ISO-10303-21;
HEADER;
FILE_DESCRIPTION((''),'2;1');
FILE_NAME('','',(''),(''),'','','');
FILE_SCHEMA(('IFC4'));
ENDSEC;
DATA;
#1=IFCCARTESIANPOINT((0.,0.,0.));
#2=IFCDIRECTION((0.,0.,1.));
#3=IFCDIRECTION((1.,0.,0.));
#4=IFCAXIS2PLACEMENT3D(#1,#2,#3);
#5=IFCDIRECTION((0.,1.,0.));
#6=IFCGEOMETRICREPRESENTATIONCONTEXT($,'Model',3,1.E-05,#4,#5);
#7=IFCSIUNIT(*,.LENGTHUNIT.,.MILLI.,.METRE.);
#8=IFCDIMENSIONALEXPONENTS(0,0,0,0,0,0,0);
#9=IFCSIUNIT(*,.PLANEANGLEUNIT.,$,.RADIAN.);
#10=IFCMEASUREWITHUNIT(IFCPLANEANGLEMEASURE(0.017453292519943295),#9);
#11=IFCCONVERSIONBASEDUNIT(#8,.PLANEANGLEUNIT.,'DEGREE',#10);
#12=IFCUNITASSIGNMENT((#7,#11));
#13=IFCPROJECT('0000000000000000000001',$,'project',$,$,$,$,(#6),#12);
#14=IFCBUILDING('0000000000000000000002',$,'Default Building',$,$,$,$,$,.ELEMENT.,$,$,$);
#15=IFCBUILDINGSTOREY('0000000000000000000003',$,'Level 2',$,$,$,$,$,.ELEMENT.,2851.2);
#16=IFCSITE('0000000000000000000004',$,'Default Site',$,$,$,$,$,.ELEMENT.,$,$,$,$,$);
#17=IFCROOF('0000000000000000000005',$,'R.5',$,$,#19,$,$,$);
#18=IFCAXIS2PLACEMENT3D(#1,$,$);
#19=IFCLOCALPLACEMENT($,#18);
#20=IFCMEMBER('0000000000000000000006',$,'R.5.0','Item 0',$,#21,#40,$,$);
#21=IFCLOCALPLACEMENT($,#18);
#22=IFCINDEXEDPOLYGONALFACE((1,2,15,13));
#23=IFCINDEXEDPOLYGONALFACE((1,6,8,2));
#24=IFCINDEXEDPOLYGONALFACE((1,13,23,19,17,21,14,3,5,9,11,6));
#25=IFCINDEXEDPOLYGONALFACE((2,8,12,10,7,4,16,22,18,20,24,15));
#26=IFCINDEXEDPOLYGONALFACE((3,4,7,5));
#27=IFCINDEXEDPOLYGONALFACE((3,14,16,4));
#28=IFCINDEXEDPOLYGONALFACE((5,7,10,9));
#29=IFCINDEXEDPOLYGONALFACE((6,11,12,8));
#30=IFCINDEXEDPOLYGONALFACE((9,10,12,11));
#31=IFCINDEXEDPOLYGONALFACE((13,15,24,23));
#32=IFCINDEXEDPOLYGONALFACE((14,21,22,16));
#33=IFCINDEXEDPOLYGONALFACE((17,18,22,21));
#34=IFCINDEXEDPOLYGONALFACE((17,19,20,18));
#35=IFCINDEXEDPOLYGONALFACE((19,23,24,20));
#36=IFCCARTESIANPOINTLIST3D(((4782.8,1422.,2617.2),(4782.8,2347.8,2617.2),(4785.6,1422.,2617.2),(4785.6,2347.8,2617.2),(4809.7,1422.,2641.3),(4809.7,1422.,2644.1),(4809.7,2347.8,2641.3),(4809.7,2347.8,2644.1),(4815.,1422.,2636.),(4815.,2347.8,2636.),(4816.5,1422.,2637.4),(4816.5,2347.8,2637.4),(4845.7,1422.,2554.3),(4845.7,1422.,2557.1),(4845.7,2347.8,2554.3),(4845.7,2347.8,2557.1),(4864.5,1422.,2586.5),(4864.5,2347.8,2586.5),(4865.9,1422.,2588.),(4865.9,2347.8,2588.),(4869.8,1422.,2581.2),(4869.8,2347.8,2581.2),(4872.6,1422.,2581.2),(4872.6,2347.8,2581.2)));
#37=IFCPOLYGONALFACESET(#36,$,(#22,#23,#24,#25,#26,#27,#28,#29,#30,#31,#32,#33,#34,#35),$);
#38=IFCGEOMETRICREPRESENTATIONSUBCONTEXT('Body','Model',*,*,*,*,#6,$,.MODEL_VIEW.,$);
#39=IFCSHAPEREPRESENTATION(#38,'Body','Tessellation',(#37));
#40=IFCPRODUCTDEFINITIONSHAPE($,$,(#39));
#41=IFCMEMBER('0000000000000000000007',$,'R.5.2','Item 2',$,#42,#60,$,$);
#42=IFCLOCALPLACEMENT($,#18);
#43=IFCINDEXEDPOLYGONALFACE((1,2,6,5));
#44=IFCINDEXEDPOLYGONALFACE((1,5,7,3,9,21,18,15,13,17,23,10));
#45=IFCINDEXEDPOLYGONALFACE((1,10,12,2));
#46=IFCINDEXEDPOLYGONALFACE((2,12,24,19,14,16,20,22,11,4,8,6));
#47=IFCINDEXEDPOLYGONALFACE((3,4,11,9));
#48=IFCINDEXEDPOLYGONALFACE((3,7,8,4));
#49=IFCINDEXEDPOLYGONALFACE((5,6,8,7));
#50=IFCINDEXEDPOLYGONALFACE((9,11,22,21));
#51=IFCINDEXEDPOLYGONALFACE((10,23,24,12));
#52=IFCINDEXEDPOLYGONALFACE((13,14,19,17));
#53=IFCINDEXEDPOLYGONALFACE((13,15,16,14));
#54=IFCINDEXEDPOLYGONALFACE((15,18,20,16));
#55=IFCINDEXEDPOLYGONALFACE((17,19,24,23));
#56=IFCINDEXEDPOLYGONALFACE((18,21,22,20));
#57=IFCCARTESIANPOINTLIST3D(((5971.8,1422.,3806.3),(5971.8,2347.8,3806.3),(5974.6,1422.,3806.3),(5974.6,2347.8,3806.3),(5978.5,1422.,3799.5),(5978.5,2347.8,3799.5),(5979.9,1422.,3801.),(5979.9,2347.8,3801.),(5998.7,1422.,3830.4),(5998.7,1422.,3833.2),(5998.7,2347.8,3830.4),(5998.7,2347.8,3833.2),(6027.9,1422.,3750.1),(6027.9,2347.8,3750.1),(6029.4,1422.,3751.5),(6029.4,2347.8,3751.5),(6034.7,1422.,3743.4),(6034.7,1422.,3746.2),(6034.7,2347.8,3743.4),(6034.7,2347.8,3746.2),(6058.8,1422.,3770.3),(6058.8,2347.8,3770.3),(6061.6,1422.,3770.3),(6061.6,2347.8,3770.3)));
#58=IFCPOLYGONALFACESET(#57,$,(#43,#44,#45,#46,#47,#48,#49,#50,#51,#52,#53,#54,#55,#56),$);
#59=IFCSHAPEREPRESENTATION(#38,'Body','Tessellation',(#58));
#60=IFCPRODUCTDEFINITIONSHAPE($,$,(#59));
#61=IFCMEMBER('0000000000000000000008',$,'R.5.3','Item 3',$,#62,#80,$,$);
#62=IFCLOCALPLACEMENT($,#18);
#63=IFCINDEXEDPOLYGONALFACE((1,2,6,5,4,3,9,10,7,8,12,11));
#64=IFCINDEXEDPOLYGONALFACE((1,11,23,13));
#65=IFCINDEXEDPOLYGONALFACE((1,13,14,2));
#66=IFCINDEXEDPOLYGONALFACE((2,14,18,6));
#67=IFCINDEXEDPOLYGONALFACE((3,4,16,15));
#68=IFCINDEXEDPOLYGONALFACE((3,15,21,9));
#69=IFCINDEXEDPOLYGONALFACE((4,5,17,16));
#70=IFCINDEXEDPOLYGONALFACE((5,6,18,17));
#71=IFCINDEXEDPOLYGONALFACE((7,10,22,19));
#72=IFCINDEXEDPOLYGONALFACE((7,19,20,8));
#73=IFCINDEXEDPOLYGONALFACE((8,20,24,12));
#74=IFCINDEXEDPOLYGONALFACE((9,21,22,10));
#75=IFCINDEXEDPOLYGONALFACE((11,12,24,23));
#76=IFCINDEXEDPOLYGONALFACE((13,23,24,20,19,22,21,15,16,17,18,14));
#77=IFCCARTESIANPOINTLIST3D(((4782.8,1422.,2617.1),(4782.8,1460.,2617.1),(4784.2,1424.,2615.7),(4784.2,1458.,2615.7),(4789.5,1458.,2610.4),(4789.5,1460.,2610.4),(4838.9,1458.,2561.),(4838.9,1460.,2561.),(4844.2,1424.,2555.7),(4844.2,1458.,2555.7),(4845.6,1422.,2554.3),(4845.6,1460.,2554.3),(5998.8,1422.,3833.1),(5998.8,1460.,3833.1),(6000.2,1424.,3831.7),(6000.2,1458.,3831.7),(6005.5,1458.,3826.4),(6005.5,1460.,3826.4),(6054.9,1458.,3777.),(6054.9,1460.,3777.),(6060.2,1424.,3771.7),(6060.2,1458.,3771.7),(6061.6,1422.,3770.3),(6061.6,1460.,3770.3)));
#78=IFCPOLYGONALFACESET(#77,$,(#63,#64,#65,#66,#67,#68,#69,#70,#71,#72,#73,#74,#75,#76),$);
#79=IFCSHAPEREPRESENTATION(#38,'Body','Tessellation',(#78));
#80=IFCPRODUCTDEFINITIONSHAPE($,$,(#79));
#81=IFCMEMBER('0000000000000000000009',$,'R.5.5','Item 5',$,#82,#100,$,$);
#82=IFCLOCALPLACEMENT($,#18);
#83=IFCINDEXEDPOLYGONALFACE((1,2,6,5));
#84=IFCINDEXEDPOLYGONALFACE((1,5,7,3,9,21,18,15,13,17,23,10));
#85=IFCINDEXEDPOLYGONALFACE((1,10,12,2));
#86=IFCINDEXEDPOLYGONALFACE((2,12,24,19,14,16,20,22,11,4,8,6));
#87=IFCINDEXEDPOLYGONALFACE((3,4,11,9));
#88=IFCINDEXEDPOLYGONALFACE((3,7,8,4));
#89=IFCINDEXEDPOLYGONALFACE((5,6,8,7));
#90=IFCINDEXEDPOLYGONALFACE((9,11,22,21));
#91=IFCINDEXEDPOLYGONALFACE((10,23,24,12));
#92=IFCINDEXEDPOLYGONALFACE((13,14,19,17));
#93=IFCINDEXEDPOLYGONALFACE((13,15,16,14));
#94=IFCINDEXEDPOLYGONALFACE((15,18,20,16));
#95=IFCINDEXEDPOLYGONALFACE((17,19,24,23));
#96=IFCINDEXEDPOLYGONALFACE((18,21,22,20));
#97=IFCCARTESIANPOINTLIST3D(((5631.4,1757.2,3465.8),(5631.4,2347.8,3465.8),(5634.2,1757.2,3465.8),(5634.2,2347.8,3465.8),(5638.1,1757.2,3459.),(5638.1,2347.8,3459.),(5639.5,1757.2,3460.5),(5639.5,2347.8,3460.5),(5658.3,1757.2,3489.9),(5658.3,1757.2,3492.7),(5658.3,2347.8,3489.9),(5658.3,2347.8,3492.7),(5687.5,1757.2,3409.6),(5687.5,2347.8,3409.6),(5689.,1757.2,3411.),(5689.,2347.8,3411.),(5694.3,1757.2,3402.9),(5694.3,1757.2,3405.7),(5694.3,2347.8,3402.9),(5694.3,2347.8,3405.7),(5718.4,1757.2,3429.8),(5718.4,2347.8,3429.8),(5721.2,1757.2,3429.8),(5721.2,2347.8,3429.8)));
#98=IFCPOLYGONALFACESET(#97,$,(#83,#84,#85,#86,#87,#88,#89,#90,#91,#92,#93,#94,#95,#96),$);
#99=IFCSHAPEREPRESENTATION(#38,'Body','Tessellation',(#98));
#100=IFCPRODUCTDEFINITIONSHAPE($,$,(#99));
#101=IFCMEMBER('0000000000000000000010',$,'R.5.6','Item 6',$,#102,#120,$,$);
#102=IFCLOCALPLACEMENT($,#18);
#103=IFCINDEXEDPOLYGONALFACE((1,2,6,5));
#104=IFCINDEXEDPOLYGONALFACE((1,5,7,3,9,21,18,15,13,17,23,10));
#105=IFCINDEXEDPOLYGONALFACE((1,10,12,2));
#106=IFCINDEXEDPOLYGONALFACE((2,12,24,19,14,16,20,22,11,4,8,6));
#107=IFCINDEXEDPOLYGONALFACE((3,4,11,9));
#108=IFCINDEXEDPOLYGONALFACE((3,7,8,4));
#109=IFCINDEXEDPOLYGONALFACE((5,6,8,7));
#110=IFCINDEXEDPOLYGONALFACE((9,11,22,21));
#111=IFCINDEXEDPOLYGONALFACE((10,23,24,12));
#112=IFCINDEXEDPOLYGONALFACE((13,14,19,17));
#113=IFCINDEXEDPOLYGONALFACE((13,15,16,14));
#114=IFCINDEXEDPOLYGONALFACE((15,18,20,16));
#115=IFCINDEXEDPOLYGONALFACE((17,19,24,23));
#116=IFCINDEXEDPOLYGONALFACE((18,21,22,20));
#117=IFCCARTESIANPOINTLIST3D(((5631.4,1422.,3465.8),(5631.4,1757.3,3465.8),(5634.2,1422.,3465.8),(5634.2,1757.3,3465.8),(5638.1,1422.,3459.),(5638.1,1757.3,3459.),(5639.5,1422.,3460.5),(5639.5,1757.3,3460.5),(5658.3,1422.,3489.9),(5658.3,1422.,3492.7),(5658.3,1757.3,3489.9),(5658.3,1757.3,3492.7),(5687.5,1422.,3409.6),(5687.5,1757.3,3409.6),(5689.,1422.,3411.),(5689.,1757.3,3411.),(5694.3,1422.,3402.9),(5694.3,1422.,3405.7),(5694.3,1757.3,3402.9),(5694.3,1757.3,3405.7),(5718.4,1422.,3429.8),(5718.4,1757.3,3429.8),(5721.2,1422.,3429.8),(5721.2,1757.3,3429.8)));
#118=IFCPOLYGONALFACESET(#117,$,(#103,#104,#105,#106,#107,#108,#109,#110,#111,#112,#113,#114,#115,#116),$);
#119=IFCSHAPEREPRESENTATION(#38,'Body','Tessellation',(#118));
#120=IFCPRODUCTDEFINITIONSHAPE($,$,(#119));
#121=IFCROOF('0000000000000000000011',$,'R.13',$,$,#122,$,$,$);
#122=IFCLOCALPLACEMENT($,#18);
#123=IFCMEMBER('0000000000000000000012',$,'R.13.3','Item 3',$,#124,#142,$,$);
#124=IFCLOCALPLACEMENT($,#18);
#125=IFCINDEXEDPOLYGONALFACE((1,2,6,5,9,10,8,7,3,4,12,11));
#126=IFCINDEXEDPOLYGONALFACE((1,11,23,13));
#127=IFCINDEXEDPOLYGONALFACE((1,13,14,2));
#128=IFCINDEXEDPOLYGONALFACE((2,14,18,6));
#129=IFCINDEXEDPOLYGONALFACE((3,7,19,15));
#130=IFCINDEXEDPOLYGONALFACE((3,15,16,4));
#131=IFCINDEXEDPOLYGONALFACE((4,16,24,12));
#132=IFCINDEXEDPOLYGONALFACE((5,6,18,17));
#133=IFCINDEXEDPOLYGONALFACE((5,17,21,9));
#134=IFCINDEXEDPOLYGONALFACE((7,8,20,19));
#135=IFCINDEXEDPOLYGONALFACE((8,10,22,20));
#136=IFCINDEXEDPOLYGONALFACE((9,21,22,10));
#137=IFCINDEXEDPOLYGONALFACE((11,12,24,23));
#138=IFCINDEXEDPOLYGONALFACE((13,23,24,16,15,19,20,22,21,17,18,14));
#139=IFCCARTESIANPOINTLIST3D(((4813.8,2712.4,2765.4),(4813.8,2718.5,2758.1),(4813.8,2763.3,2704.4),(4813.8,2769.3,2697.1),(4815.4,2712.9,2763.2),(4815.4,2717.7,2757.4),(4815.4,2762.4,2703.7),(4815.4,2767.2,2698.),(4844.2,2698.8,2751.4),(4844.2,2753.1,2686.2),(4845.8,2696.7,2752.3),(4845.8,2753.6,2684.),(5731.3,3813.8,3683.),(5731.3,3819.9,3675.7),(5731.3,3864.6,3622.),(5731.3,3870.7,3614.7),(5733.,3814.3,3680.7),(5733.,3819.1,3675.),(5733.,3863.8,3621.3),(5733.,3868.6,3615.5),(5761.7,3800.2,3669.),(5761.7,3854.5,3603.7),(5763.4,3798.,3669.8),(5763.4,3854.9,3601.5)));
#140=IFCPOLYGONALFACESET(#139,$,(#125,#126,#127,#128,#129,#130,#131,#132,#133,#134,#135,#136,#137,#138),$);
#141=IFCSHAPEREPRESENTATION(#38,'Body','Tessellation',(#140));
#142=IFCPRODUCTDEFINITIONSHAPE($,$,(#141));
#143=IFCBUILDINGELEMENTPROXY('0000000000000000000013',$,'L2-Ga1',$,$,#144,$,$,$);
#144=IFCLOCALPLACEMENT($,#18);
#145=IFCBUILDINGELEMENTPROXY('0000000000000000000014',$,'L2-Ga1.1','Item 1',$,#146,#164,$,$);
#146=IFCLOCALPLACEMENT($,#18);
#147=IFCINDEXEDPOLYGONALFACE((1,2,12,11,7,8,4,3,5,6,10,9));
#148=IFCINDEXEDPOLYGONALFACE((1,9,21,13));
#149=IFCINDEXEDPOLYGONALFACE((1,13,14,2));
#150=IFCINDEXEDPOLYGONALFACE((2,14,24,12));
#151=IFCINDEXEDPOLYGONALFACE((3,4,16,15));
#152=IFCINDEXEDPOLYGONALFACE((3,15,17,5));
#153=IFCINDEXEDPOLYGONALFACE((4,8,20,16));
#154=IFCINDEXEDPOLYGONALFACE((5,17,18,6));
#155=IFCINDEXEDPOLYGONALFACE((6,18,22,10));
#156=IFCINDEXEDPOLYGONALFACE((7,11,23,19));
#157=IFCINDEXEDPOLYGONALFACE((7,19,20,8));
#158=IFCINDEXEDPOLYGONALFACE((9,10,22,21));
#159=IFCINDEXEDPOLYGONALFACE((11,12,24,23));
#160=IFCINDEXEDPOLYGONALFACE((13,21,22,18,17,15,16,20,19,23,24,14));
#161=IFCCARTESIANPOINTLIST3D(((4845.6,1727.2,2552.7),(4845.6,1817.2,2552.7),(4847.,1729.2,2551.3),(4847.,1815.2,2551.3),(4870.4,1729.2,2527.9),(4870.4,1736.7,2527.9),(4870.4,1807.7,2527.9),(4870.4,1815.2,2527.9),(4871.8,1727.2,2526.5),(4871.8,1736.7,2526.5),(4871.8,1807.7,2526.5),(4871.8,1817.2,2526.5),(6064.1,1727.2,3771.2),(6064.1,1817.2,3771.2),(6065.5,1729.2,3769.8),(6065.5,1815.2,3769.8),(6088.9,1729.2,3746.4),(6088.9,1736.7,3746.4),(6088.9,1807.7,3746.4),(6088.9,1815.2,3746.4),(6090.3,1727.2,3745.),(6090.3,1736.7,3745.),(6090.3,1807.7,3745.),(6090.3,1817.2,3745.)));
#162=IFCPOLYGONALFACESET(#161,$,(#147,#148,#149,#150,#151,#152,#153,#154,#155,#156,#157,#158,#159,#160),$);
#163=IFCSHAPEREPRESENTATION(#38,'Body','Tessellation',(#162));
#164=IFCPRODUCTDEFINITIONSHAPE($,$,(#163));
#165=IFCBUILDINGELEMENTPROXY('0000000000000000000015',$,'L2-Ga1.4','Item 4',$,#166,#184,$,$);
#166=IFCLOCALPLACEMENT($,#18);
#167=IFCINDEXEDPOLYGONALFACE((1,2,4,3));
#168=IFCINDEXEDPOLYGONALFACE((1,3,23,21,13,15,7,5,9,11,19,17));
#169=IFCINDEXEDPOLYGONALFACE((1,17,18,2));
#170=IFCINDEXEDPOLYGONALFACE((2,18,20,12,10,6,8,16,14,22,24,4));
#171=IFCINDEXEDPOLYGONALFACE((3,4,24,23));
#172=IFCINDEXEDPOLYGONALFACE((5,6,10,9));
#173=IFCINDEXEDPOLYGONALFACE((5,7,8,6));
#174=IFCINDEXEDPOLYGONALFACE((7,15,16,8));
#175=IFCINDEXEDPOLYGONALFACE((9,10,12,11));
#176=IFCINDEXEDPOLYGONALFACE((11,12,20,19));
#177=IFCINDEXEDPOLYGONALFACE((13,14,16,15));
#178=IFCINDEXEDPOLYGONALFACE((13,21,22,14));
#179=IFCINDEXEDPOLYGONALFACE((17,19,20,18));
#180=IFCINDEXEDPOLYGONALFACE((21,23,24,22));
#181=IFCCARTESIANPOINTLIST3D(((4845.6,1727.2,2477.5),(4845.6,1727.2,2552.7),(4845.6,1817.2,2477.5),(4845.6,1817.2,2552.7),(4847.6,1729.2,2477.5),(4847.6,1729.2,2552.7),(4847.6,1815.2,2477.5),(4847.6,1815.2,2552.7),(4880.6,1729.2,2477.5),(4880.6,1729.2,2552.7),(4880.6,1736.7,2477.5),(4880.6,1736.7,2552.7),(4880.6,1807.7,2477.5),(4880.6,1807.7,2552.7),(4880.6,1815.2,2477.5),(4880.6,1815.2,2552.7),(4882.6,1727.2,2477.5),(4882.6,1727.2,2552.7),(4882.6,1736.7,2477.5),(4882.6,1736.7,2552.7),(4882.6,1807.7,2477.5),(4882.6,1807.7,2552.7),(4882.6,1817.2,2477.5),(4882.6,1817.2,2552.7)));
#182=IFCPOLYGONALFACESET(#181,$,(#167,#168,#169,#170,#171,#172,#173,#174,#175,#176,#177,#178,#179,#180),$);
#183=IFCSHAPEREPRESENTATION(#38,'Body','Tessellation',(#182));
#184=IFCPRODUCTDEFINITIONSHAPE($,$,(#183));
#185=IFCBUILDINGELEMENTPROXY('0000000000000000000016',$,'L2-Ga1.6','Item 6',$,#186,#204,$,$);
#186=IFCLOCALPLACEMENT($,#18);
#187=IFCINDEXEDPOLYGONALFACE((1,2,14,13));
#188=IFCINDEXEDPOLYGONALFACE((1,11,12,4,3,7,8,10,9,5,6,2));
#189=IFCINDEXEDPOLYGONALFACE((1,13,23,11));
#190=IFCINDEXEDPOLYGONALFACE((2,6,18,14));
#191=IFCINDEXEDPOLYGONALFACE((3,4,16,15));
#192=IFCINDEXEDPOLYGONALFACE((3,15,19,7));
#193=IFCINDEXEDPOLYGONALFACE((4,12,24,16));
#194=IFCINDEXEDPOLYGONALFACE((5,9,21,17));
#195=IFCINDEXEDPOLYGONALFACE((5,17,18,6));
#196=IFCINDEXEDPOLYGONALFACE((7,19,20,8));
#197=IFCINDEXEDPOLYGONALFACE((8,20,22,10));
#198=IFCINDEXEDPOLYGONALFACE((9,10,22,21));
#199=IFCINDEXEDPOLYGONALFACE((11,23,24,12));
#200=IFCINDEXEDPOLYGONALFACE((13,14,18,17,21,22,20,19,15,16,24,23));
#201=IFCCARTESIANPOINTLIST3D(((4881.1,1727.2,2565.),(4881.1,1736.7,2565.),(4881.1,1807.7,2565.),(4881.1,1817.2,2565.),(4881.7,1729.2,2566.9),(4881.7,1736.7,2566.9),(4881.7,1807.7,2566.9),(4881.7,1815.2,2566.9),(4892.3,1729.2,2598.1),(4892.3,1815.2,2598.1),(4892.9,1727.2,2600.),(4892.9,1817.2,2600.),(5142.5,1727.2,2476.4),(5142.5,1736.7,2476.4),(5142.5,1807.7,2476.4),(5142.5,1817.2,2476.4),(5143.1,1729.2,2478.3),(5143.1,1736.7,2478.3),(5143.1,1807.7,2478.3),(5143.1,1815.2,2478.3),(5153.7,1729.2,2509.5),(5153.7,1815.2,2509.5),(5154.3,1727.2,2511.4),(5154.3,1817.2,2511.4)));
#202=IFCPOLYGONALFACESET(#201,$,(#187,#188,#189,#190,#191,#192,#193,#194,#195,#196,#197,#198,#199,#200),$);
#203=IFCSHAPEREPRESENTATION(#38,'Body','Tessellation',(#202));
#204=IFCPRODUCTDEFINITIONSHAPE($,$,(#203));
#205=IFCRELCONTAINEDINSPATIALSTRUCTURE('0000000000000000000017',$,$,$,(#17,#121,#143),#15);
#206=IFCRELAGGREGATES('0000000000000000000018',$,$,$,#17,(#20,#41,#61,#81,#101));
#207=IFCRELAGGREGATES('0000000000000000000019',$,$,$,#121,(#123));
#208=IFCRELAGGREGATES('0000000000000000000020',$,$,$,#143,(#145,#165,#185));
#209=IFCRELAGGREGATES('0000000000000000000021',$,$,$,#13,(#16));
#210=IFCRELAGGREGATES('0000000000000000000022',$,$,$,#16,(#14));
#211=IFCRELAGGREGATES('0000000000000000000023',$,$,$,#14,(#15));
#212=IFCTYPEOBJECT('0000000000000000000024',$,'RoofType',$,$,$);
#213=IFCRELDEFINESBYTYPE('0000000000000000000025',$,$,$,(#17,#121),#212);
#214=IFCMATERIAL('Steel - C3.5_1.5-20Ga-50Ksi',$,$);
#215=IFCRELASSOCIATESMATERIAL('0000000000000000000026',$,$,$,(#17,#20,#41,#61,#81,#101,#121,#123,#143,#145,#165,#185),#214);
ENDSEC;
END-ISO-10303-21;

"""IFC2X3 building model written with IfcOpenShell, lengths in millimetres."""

from ifc_helpers import new_model, entity, si_unit, converted_unit, direction, frame, origin, origin_with_axes, origin_2d_with_axis, place, context, subcontext, project, spatial, c_section, extrude, material, type_object, element, aggregate, save


model = new_model("IFC2X3")

# Units and contexts
model_context = context("Model", 3, precision=1e-05, world=origin_with_axes(), true_north=direction((0.0, 1.0, 0.0)))
body_context = subcontext(model_context, "Body", "Model", "MODEL_VIEW")
ifc_project = project(units=[si_unit("LENGTHUNIT", "METRE", prefix="MILLI"), converted_unit("PLANEANGLEUNIT", "DEGREE", entity("IfcPlaneAngleMeasure", 0.017453292519943295), si_unit("PLANEANGLEUNIT", "RADIAN"), dimensions=[0, 0, 0, 0, 0, 0, 0])], contexts=[model_context])

# Site, building, storey
site = spatial("IfcSite", under=ifc_project, Name="Default Site", CompositionType="ELEMENT")
building = spatial("IfcBuilding", under=site, Name="Default Building", CompositionType="ELEMENT")
storey = spatial("IfcBuildingStorey", under=building, Name="Level 2", CompositionType="ELEMENT", Elevation=2851.2)

# Roof, members
ifc_material_1 = material(Name="Steel - C3.5_1.5-20Ga-50Ksi")
ifc_type_object = type_object("IfcTypeObject", Name="RoofType")
roof_1 = element("IfcRoof", 1, inside=storey, type_object=ifc_type_object, material=ifc_material_1, Name="R.5")
member_1_placement = place(None, frame((4827.7, 2347.8, 2599.2), z_axis=(0.0, -1.0, 0.0), x_axis=(0.707, 0.0, 0.707)))
member_1 = element("IfcMember", 2, at=member_1_placement, material=ifc_material_1, Name="R.5.0", Description="Item 0", context=body_context, shape_type="SweptSolid", body=[
    extrude(c_section(Depth=88.9, Width=38.1, WallThickness=2.0, Girth=9.5, at=origin_2d_with_axis()), origin(), (0.0, 0.0, 1.0), 925.8),
])
member_2_placement = place(None, frame((6016.7, 1422.0, 3788.3), z_axis=(0.0, 1.0, 0.0), x_axis=(-0.707, 0.0, -0.707)))
member_2 = element("IfcMember", 3, at=member_2_placement, material=ifc_material_1, Name="R.5.2", Description="Item 2", context=body_context, shape_type="SweptSolid", body=[
    extrude(c_section(Depth=88.9, Width=38.1, WallThickness=2.0, Girth=9.5, at=origin_2d_with_axis()), origin(), (0.0, 0.0, 1.0), 925.8),
])
member_3_placement = place(None, frame((4814.2, 1441.0, 2585.7), z_axis=(0.707, 0.0, 0.707), x_axis=(0.0, 1.0, 0.0)))
member_3 = element("IfcMember", 4, at=member_3_placement, material=ifc_material_1, Name="R.5.3", Description="Item 3", context=body_context, shape_type="SweptSolid", body=[
    extrude(c_section(Depth=88.9, Width=38.1, WallThickness=2.0, Girth=9.5, at=origin_2d_with_axis()), origin(), (0.0, 0.0, 1.0), 1719.7),
])
member_4_placement = place(None, frame((5676.3, 1757.2, 3447.8), z_axis=(0.0, 1.0, 0.0), x_axis=(-0.707, 0.0, -0.707)))
member_4 = element("IfcMember", 5, at=member_4_placement, material=ifc_material_1, Name="R.5.5", Description="Item 5", context=body_context, shape_type="SweptSolid", body=[
    extrude(c_section(Depth=88.9, Width=38.1, WallThickness=2.0, Girth=9.5, at=origin_2d_with_axis()), origin(), (0.0, 0.0, 1.0), 590.6),
])
member_5_placement = place(None, frame((5676.3, 1422.0, 3447.8), z_axis=(0.0, 1.0, 0.0), x_axis=(-0.707, 0.0, -0.707)))
member_5 = element("IfcMember", 6, at=member_5_placement, material=ifc_material_1, Name="R.5.6", Description="Item 6", context=body_context, shape_type="SweptSolid", body=[
    extrude(c_section(Depth=88.9, Width=38.1, WallThickness=2.0, Girth=9.5, at=origin_2d_with_axis()), origin(), (0.0, 0.0, 1.0), 335.3),
])
aggregate(roof_1, [member_1, member_2, member_3, member_4, member_5])

# Roof, member
roof_2 = element("IfcRoof", 7, inside=storey, type_object=ifc_type_object, material=ifc_material_1, Name="R.13")
member_6_placement = place(None, frame((4829.8, 2733.0, 2724.7), z_axis=(0.539, 0.647, 0.539), x_axis=(-0.842, 0.414, 0.345)))
member_6 = element("IfcMember", 8, at=member_6_placement, material=ifc_material_1, Name="R.13.3", Description="Item 3", context=body_context, shape_type="SweptSolid", body=[
    extrude(c_section(Depth=88.9, Width=38.1, WallThickness=2.0, Girth=9.5, at=origin_2d_with_axis()), origin(), (0.0, 0.0, 1.0), 1702.0),
])
aggregate(roof_2, [member_6])

# Building element proxies
proxy_1 = element("IfcBuildingElementProxy", 9, inside=storey, material=ifc_material_1, Name="L2-Ga1")
proxy_2_placement = place(None, frame((4858.7, 1772.2, 2539.6), z_axis=(0.707, 0.0, 0.707), x_axis=(26.163, 0.0, -26.163)))
proxy_2 = element("IfcBuildingElementProxy", 10, at=proxy_2_placement, material=ifc_material_1, Name="L2-Ga1.1", Description="Item 1", context=body_context, shape_type="SweptSolid", body=[
    extrude(c_section(Depth=90.0, Width=37.0, WallThickness=2.0, Girth=9.5, at=origin_2d_with_axis()), origin(), (0.0, 0.0, 1.0), 1723.2),
])
proxy_3_placement = place(None, frame((4864.1, 1772.2, 2477.5), z_axis=(0.0, 0.0, 1.0), x_axis=(37.0, 0.0, 0.0)))
proxy_3 = element("IfcBuildingElementProxy", 11, at=proxy_3_placement, material=ifc_material_1, Name="L2-Ga1.4", Description="Item 4", context=body_context, shape_type="SweptSolid", body=[
    extrude(c_section(Depth=90.0, Width=37.0, WallThickness=2.0, Girth=9.5, at=origin_2d_with_axis()), origin(), (0.0, 0.0, 1.0), 75.2),
])
proxy_4_placement = place(None, frame((4887.0, 1772.2, 2582.5), z_axis=(0.947, 0.0, -0.321), x_axis=(-11.868, 0.0, -35.045)))
proxy_4 = element("IfcBuildingElementProxy", 12, at=proxy_4_placement, material=ifc_material_1, Name="L2-Ga1.6", Description="Item 6", context=body_context, shape_type="SweptSolid", body=[
    extrude(c_section(Depth=90.0, Width=37.0, WallThickness=2.0, Girth=9.5, at=origin_2d_with_axis()), origin(), (0.0, 0.0, 1.0), 276.0),
])
aggregate(proxy_1, [proxy_2, proxy_3, proxy_4])

save(model, "model.ifc")
